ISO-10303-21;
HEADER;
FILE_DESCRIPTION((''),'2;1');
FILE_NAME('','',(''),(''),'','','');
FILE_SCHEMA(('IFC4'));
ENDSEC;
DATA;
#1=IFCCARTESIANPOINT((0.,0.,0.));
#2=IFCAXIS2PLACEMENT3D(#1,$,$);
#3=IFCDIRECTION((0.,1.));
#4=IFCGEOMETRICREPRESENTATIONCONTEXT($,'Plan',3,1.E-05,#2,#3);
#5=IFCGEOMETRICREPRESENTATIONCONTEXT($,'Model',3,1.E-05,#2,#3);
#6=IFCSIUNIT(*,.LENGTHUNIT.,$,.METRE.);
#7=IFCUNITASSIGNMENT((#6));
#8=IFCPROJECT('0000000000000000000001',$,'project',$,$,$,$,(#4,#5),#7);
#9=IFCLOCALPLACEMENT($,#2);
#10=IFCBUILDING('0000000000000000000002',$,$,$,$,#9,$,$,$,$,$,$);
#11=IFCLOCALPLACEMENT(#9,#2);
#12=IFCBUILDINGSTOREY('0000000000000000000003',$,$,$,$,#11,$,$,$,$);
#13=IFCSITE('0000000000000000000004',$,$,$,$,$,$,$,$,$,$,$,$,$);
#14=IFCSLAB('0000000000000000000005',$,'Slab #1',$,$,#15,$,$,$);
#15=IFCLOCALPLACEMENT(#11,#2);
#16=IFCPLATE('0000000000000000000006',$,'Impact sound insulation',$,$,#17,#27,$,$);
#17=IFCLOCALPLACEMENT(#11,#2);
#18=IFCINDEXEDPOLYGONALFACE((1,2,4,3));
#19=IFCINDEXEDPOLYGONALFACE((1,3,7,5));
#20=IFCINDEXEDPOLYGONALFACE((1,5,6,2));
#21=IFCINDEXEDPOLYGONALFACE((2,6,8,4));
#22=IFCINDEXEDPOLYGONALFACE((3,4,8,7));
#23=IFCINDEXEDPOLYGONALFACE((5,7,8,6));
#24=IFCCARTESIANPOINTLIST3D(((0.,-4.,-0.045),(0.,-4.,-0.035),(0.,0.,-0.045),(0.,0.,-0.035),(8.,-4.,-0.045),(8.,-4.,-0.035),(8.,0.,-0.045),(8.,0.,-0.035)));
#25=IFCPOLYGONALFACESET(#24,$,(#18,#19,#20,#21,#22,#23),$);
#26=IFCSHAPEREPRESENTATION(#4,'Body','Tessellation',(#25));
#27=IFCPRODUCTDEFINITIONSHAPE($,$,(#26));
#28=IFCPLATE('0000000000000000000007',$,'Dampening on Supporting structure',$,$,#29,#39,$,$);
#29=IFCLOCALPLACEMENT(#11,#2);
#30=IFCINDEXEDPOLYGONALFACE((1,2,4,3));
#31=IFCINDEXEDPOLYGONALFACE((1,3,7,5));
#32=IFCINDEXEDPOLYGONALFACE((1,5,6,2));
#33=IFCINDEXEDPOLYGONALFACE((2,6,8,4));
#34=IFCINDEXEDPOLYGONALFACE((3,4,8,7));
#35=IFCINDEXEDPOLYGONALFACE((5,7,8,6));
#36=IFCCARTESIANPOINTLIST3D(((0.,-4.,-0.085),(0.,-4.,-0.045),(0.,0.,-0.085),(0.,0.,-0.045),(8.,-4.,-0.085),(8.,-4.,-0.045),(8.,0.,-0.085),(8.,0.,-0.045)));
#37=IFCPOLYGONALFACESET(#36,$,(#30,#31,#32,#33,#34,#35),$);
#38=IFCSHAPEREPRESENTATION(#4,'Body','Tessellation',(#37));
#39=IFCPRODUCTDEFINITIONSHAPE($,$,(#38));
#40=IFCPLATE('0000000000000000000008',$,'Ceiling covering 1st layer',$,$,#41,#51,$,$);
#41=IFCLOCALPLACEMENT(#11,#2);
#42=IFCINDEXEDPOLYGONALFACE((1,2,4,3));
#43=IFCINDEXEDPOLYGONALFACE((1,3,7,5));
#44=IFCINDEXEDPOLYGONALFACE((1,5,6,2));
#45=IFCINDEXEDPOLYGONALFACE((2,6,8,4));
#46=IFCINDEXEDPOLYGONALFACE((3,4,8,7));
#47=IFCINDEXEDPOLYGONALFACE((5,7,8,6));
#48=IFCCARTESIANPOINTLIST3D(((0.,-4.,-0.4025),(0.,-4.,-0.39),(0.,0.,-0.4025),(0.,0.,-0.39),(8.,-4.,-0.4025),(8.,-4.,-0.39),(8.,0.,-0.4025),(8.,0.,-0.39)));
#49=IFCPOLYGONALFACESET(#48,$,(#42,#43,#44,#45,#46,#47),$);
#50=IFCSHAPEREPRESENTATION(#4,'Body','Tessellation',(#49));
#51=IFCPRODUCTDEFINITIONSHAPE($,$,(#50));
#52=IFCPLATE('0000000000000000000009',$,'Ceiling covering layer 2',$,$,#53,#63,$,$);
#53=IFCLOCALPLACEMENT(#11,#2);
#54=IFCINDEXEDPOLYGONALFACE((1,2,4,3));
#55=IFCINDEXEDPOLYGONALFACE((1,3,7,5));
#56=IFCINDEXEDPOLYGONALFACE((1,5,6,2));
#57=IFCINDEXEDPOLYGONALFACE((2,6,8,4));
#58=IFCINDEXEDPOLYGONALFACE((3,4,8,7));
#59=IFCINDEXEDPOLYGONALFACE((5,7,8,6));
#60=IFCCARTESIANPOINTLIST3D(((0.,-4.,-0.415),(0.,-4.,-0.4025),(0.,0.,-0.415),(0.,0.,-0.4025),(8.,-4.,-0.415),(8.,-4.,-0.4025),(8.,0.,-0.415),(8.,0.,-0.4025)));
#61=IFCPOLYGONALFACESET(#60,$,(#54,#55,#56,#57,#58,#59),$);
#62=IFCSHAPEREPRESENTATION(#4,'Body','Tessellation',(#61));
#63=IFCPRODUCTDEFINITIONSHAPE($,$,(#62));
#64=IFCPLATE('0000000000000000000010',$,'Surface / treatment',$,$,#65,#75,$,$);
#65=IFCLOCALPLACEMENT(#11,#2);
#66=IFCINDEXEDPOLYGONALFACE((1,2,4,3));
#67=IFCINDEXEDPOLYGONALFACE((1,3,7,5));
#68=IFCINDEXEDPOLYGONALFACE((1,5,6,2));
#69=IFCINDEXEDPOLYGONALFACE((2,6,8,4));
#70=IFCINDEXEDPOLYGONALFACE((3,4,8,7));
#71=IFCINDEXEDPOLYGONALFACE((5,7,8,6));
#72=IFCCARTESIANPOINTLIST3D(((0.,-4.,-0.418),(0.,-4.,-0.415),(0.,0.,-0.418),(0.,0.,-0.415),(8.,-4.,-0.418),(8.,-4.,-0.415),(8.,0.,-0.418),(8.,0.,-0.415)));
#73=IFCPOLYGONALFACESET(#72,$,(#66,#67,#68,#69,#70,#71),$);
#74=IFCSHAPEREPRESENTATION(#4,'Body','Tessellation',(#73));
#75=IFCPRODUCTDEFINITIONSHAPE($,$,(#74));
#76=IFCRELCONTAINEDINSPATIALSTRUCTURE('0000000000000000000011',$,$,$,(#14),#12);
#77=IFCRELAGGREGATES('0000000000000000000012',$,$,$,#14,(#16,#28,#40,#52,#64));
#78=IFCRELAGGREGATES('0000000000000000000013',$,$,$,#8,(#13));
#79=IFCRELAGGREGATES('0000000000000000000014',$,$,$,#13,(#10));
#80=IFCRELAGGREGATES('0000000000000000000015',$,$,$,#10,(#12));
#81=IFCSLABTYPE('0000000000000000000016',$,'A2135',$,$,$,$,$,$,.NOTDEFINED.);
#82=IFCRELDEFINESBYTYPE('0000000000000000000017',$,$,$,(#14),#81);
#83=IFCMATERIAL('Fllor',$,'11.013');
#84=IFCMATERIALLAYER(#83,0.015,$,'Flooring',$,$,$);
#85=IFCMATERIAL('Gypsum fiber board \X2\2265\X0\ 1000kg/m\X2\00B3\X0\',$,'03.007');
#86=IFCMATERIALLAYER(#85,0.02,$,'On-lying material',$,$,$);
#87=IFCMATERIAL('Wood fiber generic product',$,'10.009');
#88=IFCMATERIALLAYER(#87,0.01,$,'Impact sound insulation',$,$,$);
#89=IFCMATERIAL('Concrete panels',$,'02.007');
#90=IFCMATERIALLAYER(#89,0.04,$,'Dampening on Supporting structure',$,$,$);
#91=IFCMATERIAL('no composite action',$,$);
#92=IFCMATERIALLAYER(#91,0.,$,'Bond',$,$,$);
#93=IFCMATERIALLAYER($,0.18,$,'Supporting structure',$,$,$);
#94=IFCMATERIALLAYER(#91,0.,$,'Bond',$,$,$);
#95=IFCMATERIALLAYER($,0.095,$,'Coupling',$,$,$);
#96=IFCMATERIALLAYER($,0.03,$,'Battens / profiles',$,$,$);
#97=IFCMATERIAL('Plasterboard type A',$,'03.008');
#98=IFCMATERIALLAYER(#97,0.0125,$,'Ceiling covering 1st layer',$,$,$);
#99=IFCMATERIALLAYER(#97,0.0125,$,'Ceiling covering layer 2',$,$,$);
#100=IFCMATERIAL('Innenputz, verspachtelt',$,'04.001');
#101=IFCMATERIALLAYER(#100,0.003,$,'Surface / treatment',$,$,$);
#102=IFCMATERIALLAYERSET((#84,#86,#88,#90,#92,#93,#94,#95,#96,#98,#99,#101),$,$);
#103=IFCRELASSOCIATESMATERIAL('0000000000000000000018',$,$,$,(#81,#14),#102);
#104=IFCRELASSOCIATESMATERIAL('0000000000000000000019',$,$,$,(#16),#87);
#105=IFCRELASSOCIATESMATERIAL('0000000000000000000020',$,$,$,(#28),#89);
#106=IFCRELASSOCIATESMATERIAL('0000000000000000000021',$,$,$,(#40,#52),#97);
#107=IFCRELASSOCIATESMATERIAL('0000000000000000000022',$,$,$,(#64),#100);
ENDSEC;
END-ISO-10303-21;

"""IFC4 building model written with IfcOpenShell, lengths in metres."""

from ifc_helpers import new_model, si_unit, direction, frame, frame_2d, origin, place, context, project, spatial, rectangle, extrude, material, layer, layer_set, type_object, element, aggregate, save


model = new_model("IFC4")

# Units and contexts
plan_context = context("Plan", 3, precision=1e-05, world=origin(), true_north=direction((0.0, 1.0)))
model_context = context("Model", 3, precision=1e-05, world=origin(), true_north=direction((0.0, 1.0)))
ifc_project = project(units=[si_unit("LENGTHUNIT", "METRE")], contexts=[plan_context, model_context])

# Site, building, storey
site = spatial("IfcSite", under=ifc_project)
building_placement = place(None, origin())
building = spatial("IfcBuilding", under=site, at=building_placement)
storey_placement = place(building_placement, origin())
storey = spatial("IfcBuildingStorey", under=building, at=storey_placement)

# Slab, plates
ifc_material_1 = material(Name="Fllor", Category="11.013")
ifc_layer_1 = layer(ifc_material_1, 0.015, Name="Flooring")
ifc_material_2 = material(Name="Gypsum fiber board ≥ 1000kg/m³", Category="03.007")
ifc_layer_2 = layer(ifc_material_2, 0.02, Name="On-lying material")
ifc_material_3 = material(Name="Wood fiber generic product", Category="10.009")
ifc_layer_3 = layer(ifc_material_3, 0.01, Name="Impact sound insulation")
ifc_material_4 = material(Name="Concrete panels", Category="02.007")
ifc_layer_4 = layer(ifc_material_4, 0.04, Name="Dampening on Supporting structure")
ifc_material_5 = material(Name="no composite action")
ifc_layer_5 = layer(ifc_material_5, 0.0, Name="Bond")
ifc_layer_6 = layer(None, 0.18, Name="Supporting structure")
ifc_layer_7 = layer(ifc_material_5, 0.0, Name="Bond")
ifc_layer_8 = layer(None, 0.095, Name="Coupling")
ifc_layer_9 = layer(None, 0.03, Name="Battens / profiles")
ifc_material_6 = material(Name="Plasterboard type A", Category="03.008")
ifc_layer_10 = layer(ifc_material_6, 0.0125, Name="Ceiling covering 1st layer")
ifc_layer_11 = layer(ifc_material_6, 0.0125, Name="Ceiling covering layer 2")
ifc_material_7 = material(Name="Innenputz, verspachtelt", Category="04.001")
ifc_layer_12 = layer(ifc_material_7, 0.003, Name="Surface / treatment")
ifc_layer_set = layer_set([ifc_layer_1, ifc_layer_2, ifc_layer_3, ifc_layer_4, ifc_layer_5, ifc_layer_6, ifc_layer_7, ifc_layer_8, ifc_layer_9, ifc_layer_10, ifc_layer_11, ifc_layer_12])
slab_type = type_object("IfcSlabType", Name="A2135", PredefinedType="NOTDEFINED", material=ifc_layer_set)
slab_placement = place(None, frame((0.0, 0.0, 0.0), z_axis=(0.0, 0.0, -1.0), x_axis=(1.0, 0.0, 0.0)))
slab = element("IfcSlab", 1, at=slab_placement, inside=storey, type_object=slab_type, material=ifc_layer_set, Name="Slab #1")
plate_1_placement = place(slab_placement, origin())
plate_1 = element("IfcPlate", 2, at=plate_1_placement, material=ifc_material_3, Name="Impact sound insulation", context=plan_context, shape_type="SweptSolid", body=[
    extrude(rectangle(XDim=8.0, YDim=4.0, at=frame_2d((4.0, 2.0), x_axis=(1.0, 0.0))), frame((0.0, 0.0, 0.035), z_axis=(0.0, 0.0, 1.0), x_axis=(1.0, 0.0, 0.0)), (0.0, 0.0, 1.0), 0.01),
])
plate_2_placement = place(slab_placement, origin())
plate_2 = element("IfcPlate", 3, at=plate_2_placement, material=ifc_material_4, Name="Dampening on Supporting structure", context=plan_context, shape_type="SweptSolid", body=[
    extrude(rectangle(XDim=8.0, YDim=4.0, at=frame_2d((4.0, 2.0), x_axis=(1.0, 0.0))), frame((0.0, 0.0, 0.045), z_axis=(0.0, 0.0, 1.0), x_axis=(1.0, 0.0, 0.0)), (0.0, 0.0, 1.0), 0.04),
])
plate_3_placement = place(slab_placement, origin())
plate_3 = element("IfcPlate", 4, at=plate_3_placement, material=ifc_material_6, Name="Ceiling covering 1st layer", context=plan_context, shape_type="SweptSolid", body=[
    extrude(rectangle(XDim=8.0, YDim=4.0, at=frame_2d((4.0, 2.0), x_axis=(1.0, 0.0))), frame((0.0, 0.0, 0.39), z_axis=(0.0, 0.0, 1.0), x_axis=(1.0, 0.0, 0.0)), (0.0, 0.0, 1.0), 0.0125),
])
plate_4_placement = place(slab_placement, origin())
plate_4 = element("IfcPlate", 5, at=plate_4_placement, material=ifc_material_6, Name="Ceiling covering layer 2", context=plan_context, shape_type="SweptSolid", body=[
    extrude(rectangle(XDim=8.0, YDim=4.0, at=frame_2d((4.0, 2.0), x_axis=(1.0, 0.0))), frame((0.0, 0.0, 0.4025), z_axis=(0.0, 0.0, 1.0), x_axis=(1.0, 0.0, 0.0)), (0.0, 0.0, 1.0), 0.0125),
])
plate_5_placement = place(slab_placement, origin())
plate_5 = element("IfcPlate", 6, at=plate_5_placement, material=ifc_material_7, Name="Surface / treatment", context=plan_context, shape_type="SweptSolid", body=[
    extrude(rectangle(XDim=8.0, YDim=4.0, at=frame_2d((4.0, 2.0), x_axis=(1.0, 0.0))), frame((0.0, 0.0, 0.415), z_axis=(0.0, 0.0, 1.0), x_axis=(1.0, 0.0, 0.0)), (0.0, 0.0, 1.0), 0.003),
])
aggregate(slab, [plate_1, plate_2, plate_3, plate_4, plate_5])

save(model, "model.ifc")
